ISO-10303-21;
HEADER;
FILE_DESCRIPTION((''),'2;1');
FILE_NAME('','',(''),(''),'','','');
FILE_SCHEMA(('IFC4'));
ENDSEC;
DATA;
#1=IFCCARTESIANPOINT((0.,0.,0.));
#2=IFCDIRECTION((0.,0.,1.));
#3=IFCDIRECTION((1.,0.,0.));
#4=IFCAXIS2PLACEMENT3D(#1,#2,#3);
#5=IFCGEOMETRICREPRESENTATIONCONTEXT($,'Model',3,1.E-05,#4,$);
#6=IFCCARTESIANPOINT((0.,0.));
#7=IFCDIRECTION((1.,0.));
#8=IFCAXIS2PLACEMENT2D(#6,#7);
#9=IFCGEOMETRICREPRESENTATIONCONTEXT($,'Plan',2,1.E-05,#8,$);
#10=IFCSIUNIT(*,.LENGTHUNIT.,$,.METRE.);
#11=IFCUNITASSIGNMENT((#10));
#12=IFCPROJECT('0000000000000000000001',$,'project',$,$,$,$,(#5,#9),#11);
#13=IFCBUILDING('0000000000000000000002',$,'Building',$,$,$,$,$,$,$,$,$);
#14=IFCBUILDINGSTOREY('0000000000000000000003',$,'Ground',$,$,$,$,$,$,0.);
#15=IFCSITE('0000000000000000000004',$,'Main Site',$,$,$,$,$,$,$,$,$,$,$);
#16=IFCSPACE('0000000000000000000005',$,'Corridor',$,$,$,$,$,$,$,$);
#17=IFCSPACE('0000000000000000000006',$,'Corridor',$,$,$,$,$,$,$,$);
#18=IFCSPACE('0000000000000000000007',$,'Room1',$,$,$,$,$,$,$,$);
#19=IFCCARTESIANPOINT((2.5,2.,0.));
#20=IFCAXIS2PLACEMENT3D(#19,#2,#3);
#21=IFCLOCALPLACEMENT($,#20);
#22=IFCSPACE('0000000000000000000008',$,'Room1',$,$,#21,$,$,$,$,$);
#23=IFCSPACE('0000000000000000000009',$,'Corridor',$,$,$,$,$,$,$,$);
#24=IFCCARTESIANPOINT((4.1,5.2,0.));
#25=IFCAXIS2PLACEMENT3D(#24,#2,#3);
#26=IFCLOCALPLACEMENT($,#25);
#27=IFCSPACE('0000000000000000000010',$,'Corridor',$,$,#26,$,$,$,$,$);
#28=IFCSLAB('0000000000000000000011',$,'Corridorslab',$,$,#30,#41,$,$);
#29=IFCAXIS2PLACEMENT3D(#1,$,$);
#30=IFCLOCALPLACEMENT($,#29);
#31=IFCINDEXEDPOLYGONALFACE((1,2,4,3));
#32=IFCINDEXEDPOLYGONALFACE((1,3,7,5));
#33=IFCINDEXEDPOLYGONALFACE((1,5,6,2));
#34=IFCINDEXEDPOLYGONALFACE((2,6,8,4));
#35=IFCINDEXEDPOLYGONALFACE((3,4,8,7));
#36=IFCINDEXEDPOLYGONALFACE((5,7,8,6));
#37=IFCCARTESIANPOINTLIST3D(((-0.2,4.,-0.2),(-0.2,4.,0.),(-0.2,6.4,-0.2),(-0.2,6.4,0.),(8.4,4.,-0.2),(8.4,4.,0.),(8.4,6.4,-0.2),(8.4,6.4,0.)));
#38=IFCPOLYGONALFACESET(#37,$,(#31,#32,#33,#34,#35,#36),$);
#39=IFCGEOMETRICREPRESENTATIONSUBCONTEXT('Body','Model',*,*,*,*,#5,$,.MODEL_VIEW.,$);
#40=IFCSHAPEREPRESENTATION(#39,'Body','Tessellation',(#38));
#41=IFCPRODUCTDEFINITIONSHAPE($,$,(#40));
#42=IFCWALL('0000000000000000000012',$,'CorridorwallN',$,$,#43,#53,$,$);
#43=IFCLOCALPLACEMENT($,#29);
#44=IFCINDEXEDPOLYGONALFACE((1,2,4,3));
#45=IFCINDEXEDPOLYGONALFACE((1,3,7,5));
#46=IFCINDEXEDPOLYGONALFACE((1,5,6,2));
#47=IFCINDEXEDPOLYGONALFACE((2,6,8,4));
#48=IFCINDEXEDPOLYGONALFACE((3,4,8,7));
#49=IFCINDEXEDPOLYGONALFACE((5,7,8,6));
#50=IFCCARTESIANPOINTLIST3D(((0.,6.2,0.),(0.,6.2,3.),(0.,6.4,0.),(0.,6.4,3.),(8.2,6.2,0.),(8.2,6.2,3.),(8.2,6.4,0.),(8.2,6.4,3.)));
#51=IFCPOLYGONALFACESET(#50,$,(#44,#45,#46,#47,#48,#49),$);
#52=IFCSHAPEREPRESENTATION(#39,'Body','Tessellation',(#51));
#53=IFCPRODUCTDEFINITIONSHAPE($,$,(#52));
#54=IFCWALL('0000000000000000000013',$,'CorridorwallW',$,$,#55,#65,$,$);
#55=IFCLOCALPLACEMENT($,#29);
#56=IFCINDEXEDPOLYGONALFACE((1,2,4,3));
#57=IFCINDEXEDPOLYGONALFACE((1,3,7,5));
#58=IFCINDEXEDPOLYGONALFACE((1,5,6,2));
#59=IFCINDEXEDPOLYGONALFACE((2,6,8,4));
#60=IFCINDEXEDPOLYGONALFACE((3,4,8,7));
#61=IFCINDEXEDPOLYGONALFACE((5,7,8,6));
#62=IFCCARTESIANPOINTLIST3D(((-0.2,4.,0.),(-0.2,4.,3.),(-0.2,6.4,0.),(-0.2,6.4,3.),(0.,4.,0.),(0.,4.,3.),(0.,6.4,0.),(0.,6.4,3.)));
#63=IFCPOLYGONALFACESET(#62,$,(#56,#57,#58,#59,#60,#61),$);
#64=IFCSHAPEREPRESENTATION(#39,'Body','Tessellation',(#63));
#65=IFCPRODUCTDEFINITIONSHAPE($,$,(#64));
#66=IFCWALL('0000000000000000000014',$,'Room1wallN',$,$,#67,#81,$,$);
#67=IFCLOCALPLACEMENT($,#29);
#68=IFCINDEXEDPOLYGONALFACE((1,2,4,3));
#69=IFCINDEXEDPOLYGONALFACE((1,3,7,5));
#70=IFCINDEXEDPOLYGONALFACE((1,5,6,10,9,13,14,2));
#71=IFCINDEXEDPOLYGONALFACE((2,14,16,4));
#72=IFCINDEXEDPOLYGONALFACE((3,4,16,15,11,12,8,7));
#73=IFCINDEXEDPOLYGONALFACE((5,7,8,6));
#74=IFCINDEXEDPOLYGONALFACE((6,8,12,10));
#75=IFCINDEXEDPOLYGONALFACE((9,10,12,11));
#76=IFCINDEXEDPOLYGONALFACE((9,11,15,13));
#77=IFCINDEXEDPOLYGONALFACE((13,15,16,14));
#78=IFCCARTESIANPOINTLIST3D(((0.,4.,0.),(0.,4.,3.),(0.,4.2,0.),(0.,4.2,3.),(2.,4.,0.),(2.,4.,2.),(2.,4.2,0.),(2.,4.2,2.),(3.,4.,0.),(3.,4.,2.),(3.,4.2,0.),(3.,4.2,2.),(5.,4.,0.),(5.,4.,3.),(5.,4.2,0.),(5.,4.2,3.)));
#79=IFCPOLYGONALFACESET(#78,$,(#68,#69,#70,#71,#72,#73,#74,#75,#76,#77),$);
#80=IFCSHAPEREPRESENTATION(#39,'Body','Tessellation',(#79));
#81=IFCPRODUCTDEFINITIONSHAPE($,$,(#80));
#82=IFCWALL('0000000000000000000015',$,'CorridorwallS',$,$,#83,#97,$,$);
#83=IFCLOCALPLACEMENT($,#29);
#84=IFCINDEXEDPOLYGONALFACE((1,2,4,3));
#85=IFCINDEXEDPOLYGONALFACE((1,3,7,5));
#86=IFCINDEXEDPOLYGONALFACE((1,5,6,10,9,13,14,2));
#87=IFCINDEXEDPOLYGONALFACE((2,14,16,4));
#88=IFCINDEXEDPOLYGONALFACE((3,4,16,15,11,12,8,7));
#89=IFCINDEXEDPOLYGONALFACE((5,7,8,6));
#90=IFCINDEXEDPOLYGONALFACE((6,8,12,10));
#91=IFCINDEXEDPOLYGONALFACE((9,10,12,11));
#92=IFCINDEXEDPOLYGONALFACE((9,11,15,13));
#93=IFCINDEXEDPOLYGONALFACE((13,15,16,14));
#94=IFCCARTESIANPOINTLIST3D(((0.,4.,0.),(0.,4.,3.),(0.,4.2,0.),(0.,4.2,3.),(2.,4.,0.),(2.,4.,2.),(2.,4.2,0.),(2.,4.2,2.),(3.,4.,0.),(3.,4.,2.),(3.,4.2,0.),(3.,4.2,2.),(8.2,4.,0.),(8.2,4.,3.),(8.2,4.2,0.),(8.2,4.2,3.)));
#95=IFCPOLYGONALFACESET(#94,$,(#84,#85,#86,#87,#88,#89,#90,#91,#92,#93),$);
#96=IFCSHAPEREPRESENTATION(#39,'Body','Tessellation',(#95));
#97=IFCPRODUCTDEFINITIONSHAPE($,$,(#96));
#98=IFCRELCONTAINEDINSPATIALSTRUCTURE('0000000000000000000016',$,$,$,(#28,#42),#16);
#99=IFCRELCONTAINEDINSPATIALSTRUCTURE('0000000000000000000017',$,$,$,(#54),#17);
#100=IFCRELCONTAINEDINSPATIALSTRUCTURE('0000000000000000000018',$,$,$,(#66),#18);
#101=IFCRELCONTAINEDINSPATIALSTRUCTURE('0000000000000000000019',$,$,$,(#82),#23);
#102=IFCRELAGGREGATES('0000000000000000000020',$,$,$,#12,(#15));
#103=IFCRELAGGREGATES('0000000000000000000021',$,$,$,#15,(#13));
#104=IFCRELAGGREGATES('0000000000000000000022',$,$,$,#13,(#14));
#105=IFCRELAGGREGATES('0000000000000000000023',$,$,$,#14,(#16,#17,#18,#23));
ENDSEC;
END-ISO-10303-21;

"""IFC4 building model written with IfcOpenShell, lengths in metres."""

from ifc_helpers import new_model, si_unit, frame, origin_with_axes, origin_2d_with_axis, place, context, subcontext, project, spatial, indexed_curve, rectangle, outline, extrude, element, save


model = new_model("IFC4")

# Units and contexts
model_context = context("Model", 3, precision=1e-05, world=origin_with_axes())
plan_context = context("Plan", 2, precision=1e-05, world=origin_2d_with_axis())
body_context = subcontext(model_context, "Body", "Model", "MODEL_VIEW")
ifc_project = project(units=[si_unit("LENGTHUNIT", "METRE")], contexts=[model_context, plan_context])

# Site, building, storey, space
site = spatial("IfcSite", under=ifc_project, Name="Main Site")
building = spatial("IfcBuilding", under=site, Name="Building")
storey = spatial("IfcBuildingStorey", under=building, Name="Ground", Elevation=0.0)
space_1 = spatial("IfcSpace", under=storey, Name="Corridor")

# Slab
slab_1_placement = place(None, frame((4.1, 5.2, -0.2), z_axis=(0.0, 0.0, 1.0), x_axis=(1.0, 0.0, 0.0)))
element("IfcSlab", 1, at=slab_1_placement, inside=space_1, Name="Corridorslab", context=body_context, shape_type="SweptSolid", body=[
    extrude(rectangle(XDim=8.6, YDim=2.4), origin_with_axes(), (0.0, 0.0, 1.0), 0.2),
])

# Wall
wall_1_placement = place(None, frame((0.0, 6.2, 0.0), z_axis=(0.0, 0.0, 1.0), x_axis=(1.0, 0.0, 0.0)))
element("IfcWall", 2, at=wall_1_placement, inside=space_1, Name="CorridorwallN", context=body_context, shape_type="SweptSolid", body=[
    extrude(outline(indexed_curve([(0.0, 0.0), (0.0, 0.2), (8.2, 0.2), (8.2, 0.0), (0.0, 0.0)], self_intersect=False)), origin_with_axes(), (0.0, 0.0, 1.0), 3.0),
])

# Shared definitions
space_2 = spatial("IfcSpace", under=storey, Name="Corridor")

# Wall
wall_2_placement = place(None, frame((0.0, 4.0, 0.0), z_axis=(0.0, 0.0, 1.0), x_axis=(0.0, 1.0, 0.0)))
element("IfcWall", 3, at=wall_2_placement, inside=space_2, Name="CorridorwallW", context=body_context, shape_type="SweptSolid", body=[
    extrude(outline(indexed_curve([(0.0, 0.0), (0.0, 0.2), (2.4, 0.2), (2.4, 0.0), (0.0, 0.0)], self_intersect=False)), origin_with_axes(), (0.0, 0.0, 1.0), 3.0),
])

# Shared definitions
space_3 = spatial("IfcSpace", under=storey, Name="Room1")

# Wall
wall_3_placement = place(None, frame((0.0, 4.0, 0.0), z_axis=(0.0, 0.0, 1.0), x_axis=(1.0, 0.0, 0.0)))
wall_3 = element("IfcWall", 4, at=wall_3_placement, inside=space_3, Name="Room1wallN", context=body_context, shape_type="SweptSolid", body=[
    extrude(outline(indexed_curve([(0.0, 0.0), (0.0, 0.2), (5.0, 0.2), (5.0, 0.0), (0.0, 0.0)], self_intersect=False)), origin_with_axes(), (0.0, 0.0, 1.0), 3.0),
])

# Shared definitions
space_4_placement = place(None, frame((2.5, 2.0, 0.0), z_axis=(0.0, 0.0, 1.0), x_axis=(1.0, 0.0, 0.0)))
space_4 = spatial("IfcSpace", at=space_4_placement, Name="Room1")

# Opening
opening_1_placement = place(wall_3_placement, frame((2.0, 0.0, 0.0), z_axis=(0.0, 0.0, 1.0), x_axis=(1.0, 0.0, 0.0)))
element("IfcOpeningElement", 5, at=opening_1_placement, inside=space_4, cuts=wall_3, context=body_context, shape_type="SweptSolid", body=[
    extrude(outline(indexed_curve([(0.0, 0.0), (0.0, 0.4), (1.0, 0.4), (1.0, 0.0), (0.0, 0.0)], self_intersect=False)), origin_with_axes(), (0.0, 0.0, 1.0), 2.0),
])

# Shared definitions
space_5 = spatial("IfcSpace", under=storey, Name="Corridor")

# Wall
wall_4_placement = place(None, frame((0.0, 4.0, 0.0), z_axis=(0.0, 0.0, 1.0), x_axis=(1.0, 0.0, 0.0)))
wall_4 = element("IfcWall", 6, at=wall_4_placement, inside=space_5, Name="CorridorwallS", context=body_context, shape_type="SweptSolid", body=[
    extrude(outline(indexed_curve([(0.0, 0.0), (0.0, 0.2), (8.2, 0.2), (8.2, 0.0), (0.0, 0.0)], self_intersect=False)), origin_with_axes(), (0.0, 0.0, 1.0), 3.0),
])

# Shared definitions
space_6_placement = place(None, frame((4.1, 5.2, 0.0), z_axis=(0.0, 0.0, 1.0), x_axis=(1.0, 0.0, 0.0)))
space_6 = spatial("IfcSpace", at=space_6_placement, Name="Corridor")

# Opening
opening_2_placement = place(wall_4_placement, frame((2.0, 0.0, 0.0), z_axis=(0.0, 0.0, 1.0), x_axis=(1.0, 0.0, 0.0)))
element("IfcOpeningElement", 7, at=opening_2_placement, inside=space_6, cuts=wall_4, context=body_context, shape_type="SweptSolid", body=[
    extrude(outline(indexed_curve([(0.0, 0.0), (0.0, 0.4), (1.0, 0.4), (1.0, 0.0), (0.0, 0.0)], self_intersect=False)), origin_with_axes(), (0.0, 0.0, 1.0), 2.0),
])

save(model, "model.ifc")
